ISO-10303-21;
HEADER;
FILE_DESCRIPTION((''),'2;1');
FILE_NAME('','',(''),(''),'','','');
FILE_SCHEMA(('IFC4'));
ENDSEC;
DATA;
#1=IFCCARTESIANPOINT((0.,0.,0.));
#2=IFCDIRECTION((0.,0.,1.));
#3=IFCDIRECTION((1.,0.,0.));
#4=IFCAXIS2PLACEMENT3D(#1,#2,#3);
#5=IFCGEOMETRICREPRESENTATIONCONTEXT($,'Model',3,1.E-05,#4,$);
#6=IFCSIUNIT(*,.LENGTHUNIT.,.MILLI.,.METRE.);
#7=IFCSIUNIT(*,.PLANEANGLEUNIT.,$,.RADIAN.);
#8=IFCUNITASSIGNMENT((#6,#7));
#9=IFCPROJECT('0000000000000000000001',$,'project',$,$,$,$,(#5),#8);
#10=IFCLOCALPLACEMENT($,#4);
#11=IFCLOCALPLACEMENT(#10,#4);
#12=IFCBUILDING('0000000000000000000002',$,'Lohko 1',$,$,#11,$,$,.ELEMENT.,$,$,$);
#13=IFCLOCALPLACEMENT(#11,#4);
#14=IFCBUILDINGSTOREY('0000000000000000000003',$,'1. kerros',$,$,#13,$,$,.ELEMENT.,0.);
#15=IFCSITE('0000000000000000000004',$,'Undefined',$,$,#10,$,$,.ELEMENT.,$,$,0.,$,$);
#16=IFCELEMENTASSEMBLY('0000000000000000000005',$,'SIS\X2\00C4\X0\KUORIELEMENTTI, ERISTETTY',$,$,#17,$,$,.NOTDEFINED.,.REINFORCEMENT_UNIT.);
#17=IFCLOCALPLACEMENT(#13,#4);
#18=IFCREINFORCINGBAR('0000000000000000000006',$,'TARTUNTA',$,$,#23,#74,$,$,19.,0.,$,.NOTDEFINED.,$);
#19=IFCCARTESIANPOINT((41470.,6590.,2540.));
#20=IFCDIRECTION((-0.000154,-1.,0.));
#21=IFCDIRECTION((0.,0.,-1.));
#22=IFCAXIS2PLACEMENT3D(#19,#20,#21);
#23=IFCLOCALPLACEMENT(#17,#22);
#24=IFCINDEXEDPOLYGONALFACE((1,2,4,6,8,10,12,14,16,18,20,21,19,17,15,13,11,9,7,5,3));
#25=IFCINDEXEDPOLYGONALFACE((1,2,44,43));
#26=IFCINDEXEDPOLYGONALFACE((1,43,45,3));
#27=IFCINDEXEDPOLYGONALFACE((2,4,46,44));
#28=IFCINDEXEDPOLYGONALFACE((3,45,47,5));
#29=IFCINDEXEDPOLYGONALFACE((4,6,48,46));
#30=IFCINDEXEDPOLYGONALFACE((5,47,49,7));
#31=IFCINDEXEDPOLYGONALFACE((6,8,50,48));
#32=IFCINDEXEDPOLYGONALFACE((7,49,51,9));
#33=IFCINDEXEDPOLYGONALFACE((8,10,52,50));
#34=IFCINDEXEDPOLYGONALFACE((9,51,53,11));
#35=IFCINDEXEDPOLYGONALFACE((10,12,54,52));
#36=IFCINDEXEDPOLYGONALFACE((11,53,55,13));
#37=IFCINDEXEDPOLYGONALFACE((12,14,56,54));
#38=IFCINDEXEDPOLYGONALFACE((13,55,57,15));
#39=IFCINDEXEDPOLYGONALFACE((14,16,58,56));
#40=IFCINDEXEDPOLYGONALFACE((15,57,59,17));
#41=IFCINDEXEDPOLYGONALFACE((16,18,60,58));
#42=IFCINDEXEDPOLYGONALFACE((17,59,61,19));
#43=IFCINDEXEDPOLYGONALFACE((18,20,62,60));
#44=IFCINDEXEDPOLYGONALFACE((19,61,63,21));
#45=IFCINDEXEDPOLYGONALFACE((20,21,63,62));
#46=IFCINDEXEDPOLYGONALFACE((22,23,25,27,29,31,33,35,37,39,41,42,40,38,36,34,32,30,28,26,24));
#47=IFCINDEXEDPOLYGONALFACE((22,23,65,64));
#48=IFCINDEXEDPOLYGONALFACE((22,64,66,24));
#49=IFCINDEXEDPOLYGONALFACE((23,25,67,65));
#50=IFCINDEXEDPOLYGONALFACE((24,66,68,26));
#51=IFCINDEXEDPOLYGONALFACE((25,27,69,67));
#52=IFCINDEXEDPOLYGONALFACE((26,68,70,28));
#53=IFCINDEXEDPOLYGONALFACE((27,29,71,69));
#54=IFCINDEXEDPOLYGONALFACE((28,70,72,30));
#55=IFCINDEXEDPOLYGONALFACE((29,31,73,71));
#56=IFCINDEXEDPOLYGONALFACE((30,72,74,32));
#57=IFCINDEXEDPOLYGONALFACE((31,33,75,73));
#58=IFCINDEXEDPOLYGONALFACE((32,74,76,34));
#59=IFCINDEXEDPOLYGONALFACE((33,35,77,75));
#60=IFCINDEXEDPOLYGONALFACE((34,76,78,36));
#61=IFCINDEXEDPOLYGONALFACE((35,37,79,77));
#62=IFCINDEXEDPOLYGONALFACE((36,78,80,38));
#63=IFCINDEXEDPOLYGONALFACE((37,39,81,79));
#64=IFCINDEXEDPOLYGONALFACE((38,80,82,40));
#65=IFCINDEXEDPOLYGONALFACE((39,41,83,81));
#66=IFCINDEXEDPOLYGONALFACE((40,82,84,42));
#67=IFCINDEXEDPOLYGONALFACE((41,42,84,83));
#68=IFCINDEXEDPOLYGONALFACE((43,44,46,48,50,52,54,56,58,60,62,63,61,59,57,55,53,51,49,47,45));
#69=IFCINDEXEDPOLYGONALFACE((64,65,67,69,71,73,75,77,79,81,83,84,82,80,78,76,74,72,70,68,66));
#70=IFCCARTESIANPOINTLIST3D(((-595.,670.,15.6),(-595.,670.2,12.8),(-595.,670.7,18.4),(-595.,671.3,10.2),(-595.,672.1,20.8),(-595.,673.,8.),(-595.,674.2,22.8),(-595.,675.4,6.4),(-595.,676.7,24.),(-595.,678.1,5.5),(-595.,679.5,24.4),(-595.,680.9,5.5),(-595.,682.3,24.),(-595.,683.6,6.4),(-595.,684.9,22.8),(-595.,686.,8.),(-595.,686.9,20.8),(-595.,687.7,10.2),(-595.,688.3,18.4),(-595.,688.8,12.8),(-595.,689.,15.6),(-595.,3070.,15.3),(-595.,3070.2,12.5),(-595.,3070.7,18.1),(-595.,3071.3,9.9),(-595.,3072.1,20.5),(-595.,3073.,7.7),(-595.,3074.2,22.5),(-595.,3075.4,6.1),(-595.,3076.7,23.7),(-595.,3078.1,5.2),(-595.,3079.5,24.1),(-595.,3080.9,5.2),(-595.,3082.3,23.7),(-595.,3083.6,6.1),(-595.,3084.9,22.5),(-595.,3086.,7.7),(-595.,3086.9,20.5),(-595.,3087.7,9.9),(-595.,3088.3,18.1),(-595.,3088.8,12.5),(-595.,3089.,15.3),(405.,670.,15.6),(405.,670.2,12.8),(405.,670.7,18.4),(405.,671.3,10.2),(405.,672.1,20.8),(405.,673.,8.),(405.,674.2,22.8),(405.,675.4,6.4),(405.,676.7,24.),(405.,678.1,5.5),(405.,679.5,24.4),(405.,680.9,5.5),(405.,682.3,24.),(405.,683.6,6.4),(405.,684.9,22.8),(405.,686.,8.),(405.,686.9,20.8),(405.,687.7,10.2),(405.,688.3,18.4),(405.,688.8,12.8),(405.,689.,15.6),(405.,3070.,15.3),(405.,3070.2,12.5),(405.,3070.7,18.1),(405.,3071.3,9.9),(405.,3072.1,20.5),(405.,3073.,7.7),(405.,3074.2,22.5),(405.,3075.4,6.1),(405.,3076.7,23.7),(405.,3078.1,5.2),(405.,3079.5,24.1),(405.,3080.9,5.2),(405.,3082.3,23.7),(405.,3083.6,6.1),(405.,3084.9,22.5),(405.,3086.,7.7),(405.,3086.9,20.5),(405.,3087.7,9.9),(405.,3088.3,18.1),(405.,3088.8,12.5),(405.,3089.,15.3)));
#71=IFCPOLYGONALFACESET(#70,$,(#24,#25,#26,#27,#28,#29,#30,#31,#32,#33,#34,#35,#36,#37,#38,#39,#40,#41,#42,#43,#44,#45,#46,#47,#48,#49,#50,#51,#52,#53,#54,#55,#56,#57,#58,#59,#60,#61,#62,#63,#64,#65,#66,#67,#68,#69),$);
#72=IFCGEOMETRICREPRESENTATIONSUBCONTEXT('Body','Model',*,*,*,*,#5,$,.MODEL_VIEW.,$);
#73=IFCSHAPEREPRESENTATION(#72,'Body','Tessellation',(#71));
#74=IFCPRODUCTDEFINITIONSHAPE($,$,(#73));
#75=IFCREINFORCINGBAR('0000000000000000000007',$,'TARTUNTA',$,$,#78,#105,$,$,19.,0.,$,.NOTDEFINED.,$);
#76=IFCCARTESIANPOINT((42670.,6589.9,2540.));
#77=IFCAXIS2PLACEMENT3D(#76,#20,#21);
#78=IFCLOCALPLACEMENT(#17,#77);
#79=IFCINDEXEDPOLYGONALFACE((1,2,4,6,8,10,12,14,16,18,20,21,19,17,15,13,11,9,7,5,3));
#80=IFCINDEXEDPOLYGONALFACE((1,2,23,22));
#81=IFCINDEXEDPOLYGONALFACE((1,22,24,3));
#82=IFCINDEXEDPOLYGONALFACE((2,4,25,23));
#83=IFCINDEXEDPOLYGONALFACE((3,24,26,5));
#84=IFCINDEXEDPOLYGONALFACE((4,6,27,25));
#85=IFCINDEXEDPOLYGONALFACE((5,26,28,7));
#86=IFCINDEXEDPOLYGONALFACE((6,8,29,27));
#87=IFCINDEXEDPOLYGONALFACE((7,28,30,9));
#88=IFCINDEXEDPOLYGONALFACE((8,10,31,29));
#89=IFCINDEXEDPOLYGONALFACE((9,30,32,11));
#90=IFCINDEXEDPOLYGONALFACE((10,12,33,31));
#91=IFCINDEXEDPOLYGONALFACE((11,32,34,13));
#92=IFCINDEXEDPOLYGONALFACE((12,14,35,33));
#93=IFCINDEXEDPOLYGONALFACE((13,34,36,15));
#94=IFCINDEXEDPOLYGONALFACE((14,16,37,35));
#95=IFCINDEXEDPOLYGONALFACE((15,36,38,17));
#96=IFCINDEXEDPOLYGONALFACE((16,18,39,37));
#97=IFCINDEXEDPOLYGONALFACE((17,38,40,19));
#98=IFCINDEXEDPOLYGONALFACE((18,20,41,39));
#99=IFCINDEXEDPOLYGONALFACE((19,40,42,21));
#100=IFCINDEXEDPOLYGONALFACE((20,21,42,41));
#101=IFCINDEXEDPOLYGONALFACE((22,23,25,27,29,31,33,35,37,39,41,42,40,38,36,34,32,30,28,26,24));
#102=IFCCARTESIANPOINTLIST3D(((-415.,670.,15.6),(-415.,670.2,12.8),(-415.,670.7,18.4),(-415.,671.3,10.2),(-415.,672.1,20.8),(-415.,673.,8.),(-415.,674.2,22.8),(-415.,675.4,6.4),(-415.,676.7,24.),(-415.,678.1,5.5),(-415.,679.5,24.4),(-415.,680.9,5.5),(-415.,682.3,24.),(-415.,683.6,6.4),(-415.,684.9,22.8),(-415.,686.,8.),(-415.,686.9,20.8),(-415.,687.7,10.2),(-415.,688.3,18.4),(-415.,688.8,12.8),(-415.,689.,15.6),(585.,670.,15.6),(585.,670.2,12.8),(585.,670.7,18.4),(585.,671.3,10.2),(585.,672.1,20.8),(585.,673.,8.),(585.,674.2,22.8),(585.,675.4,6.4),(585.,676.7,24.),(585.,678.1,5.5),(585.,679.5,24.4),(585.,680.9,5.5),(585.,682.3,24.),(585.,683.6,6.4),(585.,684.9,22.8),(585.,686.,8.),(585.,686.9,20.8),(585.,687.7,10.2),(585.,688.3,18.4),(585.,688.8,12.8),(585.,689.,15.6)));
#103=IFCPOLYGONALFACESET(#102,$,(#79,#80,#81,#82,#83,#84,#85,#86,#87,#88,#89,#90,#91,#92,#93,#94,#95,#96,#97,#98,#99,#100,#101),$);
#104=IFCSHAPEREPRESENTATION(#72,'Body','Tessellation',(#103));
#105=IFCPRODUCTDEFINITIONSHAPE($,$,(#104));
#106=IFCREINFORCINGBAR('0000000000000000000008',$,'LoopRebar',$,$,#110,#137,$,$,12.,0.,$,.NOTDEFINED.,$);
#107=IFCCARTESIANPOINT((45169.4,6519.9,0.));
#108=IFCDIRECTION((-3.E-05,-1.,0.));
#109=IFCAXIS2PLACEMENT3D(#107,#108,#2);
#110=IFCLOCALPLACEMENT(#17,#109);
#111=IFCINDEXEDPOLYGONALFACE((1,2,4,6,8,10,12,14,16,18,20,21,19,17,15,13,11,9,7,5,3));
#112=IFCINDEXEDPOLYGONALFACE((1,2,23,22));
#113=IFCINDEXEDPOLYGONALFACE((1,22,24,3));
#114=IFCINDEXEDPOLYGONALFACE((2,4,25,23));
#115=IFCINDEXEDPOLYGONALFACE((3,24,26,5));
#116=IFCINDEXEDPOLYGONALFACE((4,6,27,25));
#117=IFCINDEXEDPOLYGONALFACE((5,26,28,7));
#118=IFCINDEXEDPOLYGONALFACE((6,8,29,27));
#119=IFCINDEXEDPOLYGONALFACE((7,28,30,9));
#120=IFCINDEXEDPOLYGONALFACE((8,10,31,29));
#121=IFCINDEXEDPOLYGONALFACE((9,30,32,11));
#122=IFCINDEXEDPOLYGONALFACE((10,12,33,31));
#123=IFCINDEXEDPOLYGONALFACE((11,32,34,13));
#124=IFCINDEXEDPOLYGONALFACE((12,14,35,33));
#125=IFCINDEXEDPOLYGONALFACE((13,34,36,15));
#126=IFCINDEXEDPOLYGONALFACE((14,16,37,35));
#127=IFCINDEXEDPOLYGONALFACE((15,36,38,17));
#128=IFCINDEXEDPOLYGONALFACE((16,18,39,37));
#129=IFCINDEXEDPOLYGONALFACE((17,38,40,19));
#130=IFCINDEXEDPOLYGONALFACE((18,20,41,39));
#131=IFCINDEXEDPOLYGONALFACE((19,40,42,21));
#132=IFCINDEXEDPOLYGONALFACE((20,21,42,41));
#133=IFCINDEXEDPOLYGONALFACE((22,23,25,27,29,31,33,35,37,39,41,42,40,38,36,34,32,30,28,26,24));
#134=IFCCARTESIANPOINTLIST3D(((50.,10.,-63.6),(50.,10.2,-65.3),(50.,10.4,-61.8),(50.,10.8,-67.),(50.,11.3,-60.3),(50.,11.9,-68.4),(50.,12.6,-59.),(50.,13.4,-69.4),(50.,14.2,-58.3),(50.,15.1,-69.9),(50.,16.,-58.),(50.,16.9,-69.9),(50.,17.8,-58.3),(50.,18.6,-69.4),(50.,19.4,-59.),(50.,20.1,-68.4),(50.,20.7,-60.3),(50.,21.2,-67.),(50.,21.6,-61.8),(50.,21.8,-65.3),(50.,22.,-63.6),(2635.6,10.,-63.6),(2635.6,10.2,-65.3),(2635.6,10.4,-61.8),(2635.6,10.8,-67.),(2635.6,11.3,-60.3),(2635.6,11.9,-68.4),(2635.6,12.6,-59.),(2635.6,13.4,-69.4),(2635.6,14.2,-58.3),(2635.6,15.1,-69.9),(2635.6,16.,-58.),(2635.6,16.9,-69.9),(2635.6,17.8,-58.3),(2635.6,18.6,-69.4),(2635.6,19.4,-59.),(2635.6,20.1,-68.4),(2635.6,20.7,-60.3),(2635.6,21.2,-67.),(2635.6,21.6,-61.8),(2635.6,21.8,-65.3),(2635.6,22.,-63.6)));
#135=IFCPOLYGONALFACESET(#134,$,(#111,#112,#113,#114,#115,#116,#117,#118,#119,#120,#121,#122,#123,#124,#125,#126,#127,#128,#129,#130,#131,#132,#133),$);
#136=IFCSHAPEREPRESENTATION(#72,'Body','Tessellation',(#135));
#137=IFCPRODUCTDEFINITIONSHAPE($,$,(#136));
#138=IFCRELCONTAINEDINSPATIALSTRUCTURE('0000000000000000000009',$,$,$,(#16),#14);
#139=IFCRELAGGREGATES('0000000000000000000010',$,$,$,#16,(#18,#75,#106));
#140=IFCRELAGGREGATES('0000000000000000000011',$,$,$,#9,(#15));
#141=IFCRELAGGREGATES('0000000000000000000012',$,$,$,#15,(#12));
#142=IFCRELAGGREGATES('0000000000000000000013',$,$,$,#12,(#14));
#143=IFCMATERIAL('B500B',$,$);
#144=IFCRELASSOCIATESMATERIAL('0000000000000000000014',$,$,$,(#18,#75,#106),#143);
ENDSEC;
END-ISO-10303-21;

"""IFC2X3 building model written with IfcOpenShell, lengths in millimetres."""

from ifc_helpers import new_model, entity, si_unit, frame, origin_with_axes, place, context, subcontext, project, spatial, source, transform, mapped, material, element, aggregate, save


model = new_model("IFC2X3")

# Units and contexts
model_context = context("Model", 3, precision=1e-05, world=origin_with_axes())
body_context = subcontext(model_context, "Body", "Model", "MODEL_VIEW")
ifc_project = project(units=[si_unit("LENGTHUNIT", "METRE", prefix="MILLI"), si_unit("PLANEANGLEUNIT", "RADIAN")], contexts=[model_context])

# Site, building, storey
site_placement = place(None, origin_with_axes())
site = spatial("IfcSite", under=ifc_project, at=site_placement, Name="Undefined", CompositionType="ELEMENT", RefElevation=0.0)
building_placement = place(site_placement, origin_with_axes())
building = spatial("IfcBuilding", under=site, at=building_placement, Name="Lohko 1", CompositionType="ELEMENT")
storey_placement = place(building_placement, origin_with_axes())
storey = spatial("IfcBuildingStorey", under=building, at=storey_placement, Name="1. kerros", CompositionType="ELEMENT", Elevation=0.0)

# Element assembly, reinforcing bars
assembly_placement = place(storey_placement, origin_with_axes())
assembly = element("IfcElementAssembly", 1, at=assembly_placement, inside=storey, Name="SISÄKUORIELEMENTTI, ERISTETTY", AssemblyPlace="NOTDEFINED", PredefinedType="REINFORCEMENT_UNIT")
ifc_material_1 = material(Name="B500B")
shared_shape_1 = source(origin_with_axes(), body_context, "Body", "AdvancedSweptSolid", [
    entity("IfcSweptDiskSolid", entity("IfcTrimmedCurve", entity("IfcLine", entity("IfcCartesianPoint", [0.0, 0.0, 0.0]), entity("IfcVector", entity("IfcDirection", [1.0, 0.0, 0.0]), 1.0)), [entity("IfcParameterValue", 0.0)], [entity("IfcParameterValue", 1000.0)], True, "PARAMETER"), 9.5, None, 0.0, 1000.0),
])
shared_shape_2 = source(origin_with_axes(), body_context, "Body", "AdvancedSweptSolid", [
    entity("IfcSweptDiskSolid", entity("IfcTrimmedCurve", entity("IfcLine", entity("IfcCartesianPoint", [0.0, 0.0, 0.0]), entity("IfcVector", entity("IfcDirection", [1.0, 0.0, 0.0]), 1.0)), [entity("IfcParameterValue", 0.0)], [entity("IfcParameterValue", 1000.0)], True, "PARAMETER"), 9.5, None, 0.0, 1000.0),
])
reinforcing_bar_1_placement = place(assembly_placement, frame((41470.0, 6590.0, 2540.0), z_axis=(-0.000154, -1.0, 0.0), x_axis=(0.0, 0.0, -1.0)))
reinforcing_bar_1 = element("IfcReinforcingBar", 2, at=reinforcing_bar_1_placement, material=ifc_material_1, Name="TARTUNTA", BarRole="NOTDEFINED", CrossSectionArea=0.0, NominalDiameter=19.0, context=body_context, shape_type="MappedRepresentation", body=[
    mapped(shared_shape_1, transform((-595.0, 679.5, 14.9))),
    mapped(shared_shape_2, transform((-595.0, 3079.5, 14.6))),
])
shared_shape_3 = source(origin_with_axes(), body_context, "Body", "AdvancedSweptSolid", [
    entity("IfcSweptDiskSolid", entity("IfcTrimmedCurve", entity("IfcLine", entity("IfcCartesianPoint", [0.0, 0.0, 0.0]), entity("IfcVector", entity("IfcDirection", [1.0, 0.0, 0.0]), 1.0)), [entity("IfcParameterValue", 0.0)], [entity("IfcParameterValue", 1000.0)], True, "PARAMETER"), 9.5, None, 0.0, 1000.0),
])
reinforcing_bar_2_placement = place(assembly_placement, frame((42670.0, 6589.9, 2540.0), z_axis=(-0.000154, -1.0, 0.0), x_axis=(0.0, 0.0, -1.0)))
reinforcing_bar_2 = element("IfcReinforcingBar", 3, at=reinforcing_bar_2_placement, material=ifc_material_1, Name="TARTUNTA", BarRole="NOTDEFINED", CrossSectionArea=0.0, NominalDiameter=19.0, context=body_context, shape_type="MappedRepresentation", body=[
    mapped(shared_shape_3, transform((-415.0, 679.5, 14.9))),
])
shared_shape_4 = source(origin_with_axes(), body_context, "Body", "AdvancedSweptSolid", [
    entity("IfcSweptDiskSolid", entity("IfcTrimmedCurve", entity("IfcLine", entity("IfcCartesianPoint", [0.0, 0.0, 0.0]), entity("IfcVector", entity("IfcDirection", [1.0, 0.0, 0.0]), 1.0)), [entity("IfcParameterValue", 0.0)], [entity("IfcParameterValue", 2585.644988)], True, "PARAMETER"), 6.0, None, 0.0, 2585.6),
])
reinforcing_bar_3_placement = place(assembly_placement, frame((45169.4, 6519.9, 0.0), z_axis=(-0.00003, -1.0, 0.0), x_axis=(0.0, 0.0, 1.0)))
reinforcing_bar_3 = element("IfcReinforcingBar", 4, at=reinforcing_bar_3_placement, material=ifc_material_1, Name="LoopRebar", BarRole="NOTDEFINED", CrossSectionArea=0.0, NominalDiameter=12.0, context=body_context, shape_type="MappedRepresentation", body=[
    mapped(shared_shape_4, transform((50.0, 16.0, -64.0))),
])
aggregate(assembly, [reinforcing_bar_1, reinforcing_bar_2, reinforcing_bar_3])

save(model, "model.ifc")
